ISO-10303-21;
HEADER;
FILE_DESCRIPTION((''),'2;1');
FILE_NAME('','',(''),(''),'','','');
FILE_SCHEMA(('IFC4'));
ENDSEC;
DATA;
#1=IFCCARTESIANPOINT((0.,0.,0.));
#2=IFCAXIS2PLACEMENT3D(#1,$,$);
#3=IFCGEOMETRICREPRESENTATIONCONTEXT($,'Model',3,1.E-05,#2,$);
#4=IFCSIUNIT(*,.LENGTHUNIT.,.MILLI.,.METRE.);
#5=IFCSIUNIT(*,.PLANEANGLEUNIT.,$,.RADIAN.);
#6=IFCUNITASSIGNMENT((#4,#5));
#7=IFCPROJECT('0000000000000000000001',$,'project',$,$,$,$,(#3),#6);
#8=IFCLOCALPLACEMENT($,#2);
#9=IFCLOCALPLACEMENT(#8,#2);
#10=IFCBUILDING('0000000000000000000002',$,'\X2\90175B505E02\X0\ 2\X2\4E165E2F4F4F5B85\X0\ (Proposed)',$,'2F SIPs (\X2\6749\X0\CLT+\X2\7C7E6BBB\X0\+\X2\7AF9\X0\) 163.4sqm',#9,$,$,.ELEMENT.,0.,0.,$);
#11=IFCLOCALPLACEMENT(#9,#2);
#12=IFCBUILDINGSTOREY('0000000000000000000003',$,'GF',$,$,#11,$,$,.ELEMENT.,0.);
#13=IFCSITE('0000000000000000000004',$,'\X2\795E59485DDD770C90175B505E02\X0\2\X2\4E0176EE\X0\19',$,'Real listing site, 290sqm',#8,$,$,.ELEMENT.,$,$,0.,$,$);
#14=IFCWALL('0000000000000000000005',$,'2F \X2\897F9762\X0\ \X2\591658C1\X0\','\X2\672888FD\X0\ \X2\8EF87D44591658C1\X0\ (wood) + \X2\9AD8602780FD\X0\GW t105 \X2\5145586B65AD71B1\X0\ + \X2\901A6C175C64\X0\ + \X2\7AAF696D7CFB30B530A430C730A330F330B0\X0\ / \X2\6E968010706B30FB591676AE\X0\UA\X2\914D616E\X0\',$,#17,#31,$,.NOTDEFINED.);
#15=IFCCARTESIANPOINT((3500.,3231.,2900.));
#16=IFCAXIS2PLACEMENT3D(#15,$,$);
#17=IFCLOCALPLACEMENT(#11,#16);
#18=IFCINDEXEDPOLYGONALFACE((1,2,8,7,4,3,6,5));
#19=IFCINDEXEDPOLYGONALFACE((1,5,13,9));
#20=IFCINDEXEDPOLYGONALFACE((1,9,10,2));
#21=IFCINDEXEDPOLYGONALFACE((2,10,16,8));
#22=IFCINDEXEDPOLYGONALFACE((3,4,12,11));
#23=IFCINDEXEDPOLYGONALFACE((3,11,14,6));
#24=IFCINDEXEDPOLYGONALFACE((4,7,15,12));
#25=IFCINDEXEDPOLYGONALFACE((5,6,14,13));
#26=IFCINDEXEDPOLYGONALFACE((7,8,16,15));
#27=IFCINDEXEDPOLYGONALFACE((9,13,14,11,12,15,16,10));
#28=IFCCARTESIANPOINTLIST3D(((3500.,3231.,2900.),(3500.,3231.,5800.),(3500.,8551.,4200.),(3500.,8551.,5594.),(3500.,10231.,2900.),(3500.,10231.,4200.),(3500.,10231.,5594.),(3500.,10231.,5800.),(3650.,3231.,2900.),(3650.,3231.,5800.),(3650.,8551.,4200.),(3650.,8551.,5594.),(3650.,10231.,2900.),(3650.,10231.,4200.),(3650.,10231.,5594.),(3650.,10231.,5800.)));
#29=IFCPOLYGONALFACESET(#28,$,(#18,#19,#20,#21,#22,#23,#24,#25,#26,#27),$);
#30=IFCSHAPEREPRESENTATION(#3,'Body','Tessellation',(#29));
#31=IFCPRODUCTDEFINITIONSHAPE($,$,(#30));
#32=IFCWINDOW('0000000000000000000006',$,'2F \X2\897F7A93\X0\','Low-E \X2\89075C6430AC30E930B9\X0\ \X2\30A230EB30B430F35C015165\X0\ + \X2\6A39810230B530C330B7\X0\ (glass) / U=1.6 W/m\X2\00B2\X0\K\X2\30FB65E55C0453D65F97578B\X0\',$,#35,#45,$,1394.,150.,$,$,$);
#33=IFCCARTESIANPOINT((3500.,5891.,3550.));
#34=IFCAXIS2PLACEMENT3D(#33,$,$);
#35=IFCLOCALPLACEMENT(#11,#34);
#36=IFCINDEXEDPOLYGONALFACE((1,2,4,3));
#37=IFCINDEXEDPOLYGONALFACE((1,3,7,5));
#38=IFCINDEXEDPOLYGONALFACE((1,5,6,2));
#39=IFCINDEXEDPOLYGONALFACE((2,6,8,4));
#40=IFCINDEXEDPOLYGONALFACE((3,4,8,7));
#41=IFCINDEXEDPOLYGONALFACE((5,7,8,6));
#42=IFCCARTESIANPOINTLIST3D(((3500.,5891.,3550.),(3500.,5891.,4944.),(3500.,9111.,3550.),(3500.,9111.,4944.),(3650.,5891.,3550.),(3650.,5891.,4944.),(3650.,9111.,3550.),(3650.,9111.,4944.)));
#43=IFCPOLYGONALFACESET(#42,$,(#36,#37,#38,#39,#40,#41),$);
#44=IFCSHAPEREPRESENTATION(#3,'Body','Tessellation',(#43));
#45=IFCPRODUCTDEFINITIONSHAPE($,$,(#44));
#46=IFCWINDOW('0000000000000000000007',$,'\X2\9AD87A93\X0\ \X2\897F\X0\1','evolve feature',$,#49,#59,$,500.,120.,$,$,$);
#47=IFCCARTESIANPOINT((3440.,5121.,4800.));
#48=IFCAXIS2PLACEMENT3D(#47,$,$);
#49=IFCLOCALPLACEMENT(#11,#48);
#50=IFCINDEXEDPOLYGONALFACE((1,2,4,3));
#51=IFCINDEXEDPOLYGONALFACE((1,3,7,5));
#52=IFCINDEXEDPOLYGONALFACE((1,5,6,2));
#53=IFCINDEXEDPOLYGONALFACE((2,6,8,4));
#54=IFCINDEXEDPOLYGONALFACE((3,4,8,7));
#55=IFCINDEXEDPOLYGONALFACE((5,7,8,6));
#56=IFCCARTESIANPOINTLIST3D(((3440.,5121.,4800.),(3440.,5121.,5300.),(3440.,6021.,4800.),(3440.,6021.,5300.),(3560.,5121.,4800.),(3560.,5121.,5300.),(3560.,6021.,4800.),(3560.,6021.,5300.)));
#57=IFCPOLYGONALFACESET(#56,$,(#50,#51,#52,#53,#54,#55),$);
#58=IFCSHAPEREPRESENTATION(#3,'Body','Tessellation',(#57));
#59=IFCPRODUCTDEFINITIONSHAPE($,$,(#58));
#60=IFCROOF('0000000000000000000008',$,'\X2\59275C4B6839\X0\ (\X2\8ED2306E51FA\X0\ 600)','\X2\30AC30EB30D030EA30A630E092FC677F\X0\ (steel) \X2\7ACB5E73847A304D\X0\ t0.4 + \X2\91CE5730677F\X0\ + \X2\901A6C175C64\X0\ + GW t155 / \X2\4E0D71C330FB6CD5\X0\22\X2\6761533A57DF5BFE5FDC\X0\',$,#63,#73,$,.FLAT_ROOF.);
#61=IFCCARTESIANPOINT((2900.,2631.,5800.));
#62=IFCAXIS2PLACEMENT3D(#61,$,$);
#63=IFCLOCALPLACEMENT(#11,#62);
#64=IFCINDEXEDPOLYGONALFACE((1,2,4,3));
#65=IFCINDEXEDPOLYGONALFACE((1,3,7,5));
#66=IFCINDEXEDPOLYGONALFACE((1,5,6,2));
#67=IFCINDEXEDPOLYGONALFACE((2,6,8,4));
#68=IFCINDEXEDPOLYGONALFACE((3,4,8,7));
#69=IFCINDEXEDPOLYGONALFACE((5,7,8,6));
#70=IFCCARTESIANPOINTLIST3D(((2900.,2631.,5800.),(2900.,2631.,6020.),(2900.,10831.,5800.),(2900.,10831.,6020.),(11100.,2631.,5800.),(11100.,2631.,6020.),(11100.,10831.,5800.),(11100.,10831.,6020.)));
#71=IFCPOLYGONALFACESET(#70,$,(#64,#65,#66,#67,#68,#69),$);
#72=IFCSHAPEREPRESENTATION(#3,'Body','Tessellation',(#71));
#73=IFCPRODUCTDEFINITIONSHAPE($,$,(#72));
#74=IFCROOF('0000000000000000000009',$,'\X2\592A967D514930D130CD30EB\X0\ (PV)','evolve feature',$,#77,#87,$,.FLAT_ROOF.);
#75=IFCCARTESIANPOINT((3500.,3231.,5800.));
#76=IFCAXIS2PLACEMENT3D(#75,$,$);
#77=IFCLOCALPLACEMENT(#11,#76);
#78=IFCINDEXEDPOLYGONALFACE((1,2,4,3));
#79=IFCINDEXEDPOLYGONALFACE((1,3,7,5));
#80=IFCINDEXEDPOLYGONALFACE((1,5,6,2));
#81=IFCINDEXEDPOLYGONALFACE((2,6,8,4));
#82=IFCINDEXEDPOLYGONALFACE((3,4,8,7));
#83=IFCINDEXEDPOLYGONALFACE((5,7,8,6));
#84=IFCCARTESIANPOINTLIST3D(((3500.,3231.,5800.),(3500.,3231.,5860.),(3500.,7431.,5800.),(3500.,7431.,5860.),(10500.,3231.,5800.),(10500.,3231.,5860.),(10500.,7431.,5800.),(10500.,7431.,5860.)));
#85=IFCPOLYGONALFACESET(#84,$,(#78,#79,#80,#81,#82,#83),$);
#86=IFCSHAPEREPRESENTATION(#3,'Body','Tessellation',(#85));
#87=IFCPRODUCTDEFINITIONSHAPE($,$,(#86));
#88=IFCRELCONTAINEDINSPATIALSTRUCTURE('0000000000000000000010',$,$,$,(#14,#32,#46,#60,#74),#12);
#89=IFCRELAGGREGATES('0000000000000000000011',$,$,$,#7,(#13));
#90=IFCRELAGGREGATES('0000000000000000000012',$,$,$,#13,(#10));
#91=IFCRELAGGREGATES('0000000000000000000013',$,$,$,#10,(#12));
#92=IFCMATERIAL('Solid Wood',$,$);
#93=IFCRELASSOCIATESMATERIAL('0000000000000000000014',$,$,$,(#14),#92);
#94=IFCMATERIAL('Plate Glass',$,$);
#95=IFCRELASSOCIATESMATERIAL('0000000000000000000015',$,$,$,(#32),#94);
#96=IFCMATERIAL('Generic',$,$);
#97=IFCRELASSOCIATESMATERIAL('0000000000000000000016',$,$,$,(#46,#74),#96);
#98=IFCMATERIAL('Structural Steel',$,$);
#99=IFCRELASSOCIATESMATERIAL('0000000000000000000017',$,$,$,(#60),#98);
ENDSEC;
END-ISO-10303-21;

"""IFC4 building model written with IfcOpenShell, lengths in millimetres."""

from ifc_helpers import new_model, si_unit, frame, frame_2d, origin, place, context, project, spatial, rectangle, extrude, material, element, fill, save


model = new_model("IFC4")

# Units and contexts
model_context = context("Model", 3, precision=1e-05, world=origin())
ifc_project = project(units=[si_unit("LENGTHUNIT", "METRE", prefix="MILLI"), si_unit("PLANEANGLEUNIT", "RADIAN")], contexts=[model_context])

# Site, building, storey
site_placement = place(None, origin())
site = spatial("IfcSite", under=ifc_project, at=site_placement, Name="神奈川県逗子市2丁目19", ObjectType="Real listing site, 290sqm", CompositionType="ELEMENT", RefElevation=0.0)
building_placement = place(site_placement, origin())
building = spatial("IfcBuilding", under=site, at=building_placement, Name="逗子市 2世帯住宅 (Proposed)", ObjectType="2F SIPs (杉CLT+籾殻+竹) 163.4sqm", CompositionType="ELEMENT", ElevationOfRefHeight=0.0, ElevationOfTerrain=0.0)
storey_placement = place(building_placement, origin())
storey = spatial("IfcBuildingStorey", under=building, at=storey_placement, Name="GF", CompositionType="ELEMENT", Elevation=0.0)

# Shared definitions
ifc_material_1 = material(Name="Solid Wood")
ifc_material_2 = material(Name="Generic")

# Shared definitions
ifc_material_3 = material(Name="Plate Glass")

# Wall, openings, windows
wall_1_placement = place(storey_placement, frame((3500.0, 3231.0, 2900.0)))
wall_1 = element("IfcWall", 1, at=wall_1_placement, inside=storey, material=ifc_material_1, Name="2F 西面 外壁", Description="木製 軸組外壁 (wood) + 高性能GW t105 充填断熱 + 通気層 + 窯業系サイディング / 準耐火・外皮UA配慮", PredefinedType="NOTDEFINED", context=model_context, shape_type="SweptSolid", body=[
    extrude(rectangle(XDim=150.0, YDim=7000.0, at=frame_2d((75.0, 3500.0))), frame((3500.0, 3231.0, 2900.0)), (0.0, 0.0, 1.0), 2900.0),
])
opening_1_placement = place(storey_placement, frame((3500.0, 5891.0, 3550.0)))
opening_1 = element("IfcOpeningElement", 2, at=opening_1_placement, cuts=wall_1, PredefinedType="NOTDEFINED", context=model_context, shape_type="SweptSolid", body=[
    extrude(rectangle(XDim=150.0, YDim=3220.0, at=frame_2d((75.0, 1610.0))), frame((3500.0, 5891.0, 3550.0)), (0.0, 0.0, 1.0), 1394.0),
])
opening_2_placement = place(storey_placement, frame((3440.0, 5121.0, 4800.0)))
opening_2 = element("IfcOpeningElement", 3, at=opening_2_placement, cuts=wall_1, PredefinedType="NOTDEFINED", context=model_context, shape_type="SweptSolid", body=[
    extrude(rectangle(XDim=120.0, YDim=900.0, at=frame_2d((60.0, 450.0))), frame((3440.0, 5121.0, 4800.0)), (0.0, 0.0, 1.0), 500.0),
])
window_1_placement = place(storey_placement, frame((3500.0, 5891.0, 3550.0)))
window_1 = element("IfcWindow", 4, at=window_1_placement, inside=storey, material=ifc_material_3, Name="2F 西窓", Description="Low-E 複層ガラス アルゴン封入 + 樹脂サッシ (glass) / U=1.6 W/m²K・日射取得型", OverallHeight=1394.0, OverallWidth=150.0, context=model_context, shape_type="SweptSolid", body=[
    extrude(rectangle(XDim=150.0, YDim=3220.0, at=frame_2d((75.0, 1610.0))), frame((3500.0, 5891.0, 3550.0)), (0.0, 0.0, 1.0), 1394.0),
])
fill(opening_1, window_1)
window_2_placement = place(storey_placement, frame((3440.0, 5121.0, 4800.0)))
window_2 = element("IfcWindow", 5, at=window_2_placement, inside=storey, material=ifc_material_2, Name="高窓 西1", Description="evolve feature", OverallHeight=500.0, OverallWidth=120.0, context=model_context, shape_type="SweptSolid", body=[
    extrude(rectangle(XDim=120.0, YDim=900.0, at=frame_2d((60.0, 450.0))), frame((3440.0, 5121.0, 4800.0)), (0.0, 0.0, 1.0), 500.0),
])
fill(opening_2, window_2)

# Roofs
ifc_material_4 = material(Name="Structural Steel")
roof_1_placement = place(storey_placement, frame((2900.0, 2631.0, 5800.0)))
element("IfcRoof", 6, at=roof_1_placement, inside=storey, material=ifc_material_4, Name="大屋根 (軒の出 600)", Description="ガルバリウム鋼板 (steel) 立平葺き t0.4 + 野地板 + 通気層 + GW t155 / 不燃・法22条区域対応", PredefinedType="FLAT_ROOF", context=model_context, shape_type="SweptSolid", body=[
    extrude(rectangle(XDim=8200.0, YDim=8200.0, at=frame_2d((4100.0, 4100.0))), frame((2900.0, 2631.0, 5800.0)), (0.0, 0.0, 1.0), 220.0),
])
roof_2_placement = place(storey_placement, frame((3500.0, 3231.0, 5800.0)))
element("IfcRoof", 7, at=roof_2_placement, inside=storey, material=ifc_material_2, Name="太陽光パネル (PV)", Description="evolve feature", PredefinedType="FLAT_ROOF", context=model_context, shape_type="SweptSolid", body=[
    extrude(rectangle(XDim=7000.0, YDim=4200.0, at=frame_2d((3500.0, 2100.0))), frame((3500.0, 3231.0, 5800.0)), (0.0, 0.0, 1.0), 60.0),
])

save(model, "model.ifc")
